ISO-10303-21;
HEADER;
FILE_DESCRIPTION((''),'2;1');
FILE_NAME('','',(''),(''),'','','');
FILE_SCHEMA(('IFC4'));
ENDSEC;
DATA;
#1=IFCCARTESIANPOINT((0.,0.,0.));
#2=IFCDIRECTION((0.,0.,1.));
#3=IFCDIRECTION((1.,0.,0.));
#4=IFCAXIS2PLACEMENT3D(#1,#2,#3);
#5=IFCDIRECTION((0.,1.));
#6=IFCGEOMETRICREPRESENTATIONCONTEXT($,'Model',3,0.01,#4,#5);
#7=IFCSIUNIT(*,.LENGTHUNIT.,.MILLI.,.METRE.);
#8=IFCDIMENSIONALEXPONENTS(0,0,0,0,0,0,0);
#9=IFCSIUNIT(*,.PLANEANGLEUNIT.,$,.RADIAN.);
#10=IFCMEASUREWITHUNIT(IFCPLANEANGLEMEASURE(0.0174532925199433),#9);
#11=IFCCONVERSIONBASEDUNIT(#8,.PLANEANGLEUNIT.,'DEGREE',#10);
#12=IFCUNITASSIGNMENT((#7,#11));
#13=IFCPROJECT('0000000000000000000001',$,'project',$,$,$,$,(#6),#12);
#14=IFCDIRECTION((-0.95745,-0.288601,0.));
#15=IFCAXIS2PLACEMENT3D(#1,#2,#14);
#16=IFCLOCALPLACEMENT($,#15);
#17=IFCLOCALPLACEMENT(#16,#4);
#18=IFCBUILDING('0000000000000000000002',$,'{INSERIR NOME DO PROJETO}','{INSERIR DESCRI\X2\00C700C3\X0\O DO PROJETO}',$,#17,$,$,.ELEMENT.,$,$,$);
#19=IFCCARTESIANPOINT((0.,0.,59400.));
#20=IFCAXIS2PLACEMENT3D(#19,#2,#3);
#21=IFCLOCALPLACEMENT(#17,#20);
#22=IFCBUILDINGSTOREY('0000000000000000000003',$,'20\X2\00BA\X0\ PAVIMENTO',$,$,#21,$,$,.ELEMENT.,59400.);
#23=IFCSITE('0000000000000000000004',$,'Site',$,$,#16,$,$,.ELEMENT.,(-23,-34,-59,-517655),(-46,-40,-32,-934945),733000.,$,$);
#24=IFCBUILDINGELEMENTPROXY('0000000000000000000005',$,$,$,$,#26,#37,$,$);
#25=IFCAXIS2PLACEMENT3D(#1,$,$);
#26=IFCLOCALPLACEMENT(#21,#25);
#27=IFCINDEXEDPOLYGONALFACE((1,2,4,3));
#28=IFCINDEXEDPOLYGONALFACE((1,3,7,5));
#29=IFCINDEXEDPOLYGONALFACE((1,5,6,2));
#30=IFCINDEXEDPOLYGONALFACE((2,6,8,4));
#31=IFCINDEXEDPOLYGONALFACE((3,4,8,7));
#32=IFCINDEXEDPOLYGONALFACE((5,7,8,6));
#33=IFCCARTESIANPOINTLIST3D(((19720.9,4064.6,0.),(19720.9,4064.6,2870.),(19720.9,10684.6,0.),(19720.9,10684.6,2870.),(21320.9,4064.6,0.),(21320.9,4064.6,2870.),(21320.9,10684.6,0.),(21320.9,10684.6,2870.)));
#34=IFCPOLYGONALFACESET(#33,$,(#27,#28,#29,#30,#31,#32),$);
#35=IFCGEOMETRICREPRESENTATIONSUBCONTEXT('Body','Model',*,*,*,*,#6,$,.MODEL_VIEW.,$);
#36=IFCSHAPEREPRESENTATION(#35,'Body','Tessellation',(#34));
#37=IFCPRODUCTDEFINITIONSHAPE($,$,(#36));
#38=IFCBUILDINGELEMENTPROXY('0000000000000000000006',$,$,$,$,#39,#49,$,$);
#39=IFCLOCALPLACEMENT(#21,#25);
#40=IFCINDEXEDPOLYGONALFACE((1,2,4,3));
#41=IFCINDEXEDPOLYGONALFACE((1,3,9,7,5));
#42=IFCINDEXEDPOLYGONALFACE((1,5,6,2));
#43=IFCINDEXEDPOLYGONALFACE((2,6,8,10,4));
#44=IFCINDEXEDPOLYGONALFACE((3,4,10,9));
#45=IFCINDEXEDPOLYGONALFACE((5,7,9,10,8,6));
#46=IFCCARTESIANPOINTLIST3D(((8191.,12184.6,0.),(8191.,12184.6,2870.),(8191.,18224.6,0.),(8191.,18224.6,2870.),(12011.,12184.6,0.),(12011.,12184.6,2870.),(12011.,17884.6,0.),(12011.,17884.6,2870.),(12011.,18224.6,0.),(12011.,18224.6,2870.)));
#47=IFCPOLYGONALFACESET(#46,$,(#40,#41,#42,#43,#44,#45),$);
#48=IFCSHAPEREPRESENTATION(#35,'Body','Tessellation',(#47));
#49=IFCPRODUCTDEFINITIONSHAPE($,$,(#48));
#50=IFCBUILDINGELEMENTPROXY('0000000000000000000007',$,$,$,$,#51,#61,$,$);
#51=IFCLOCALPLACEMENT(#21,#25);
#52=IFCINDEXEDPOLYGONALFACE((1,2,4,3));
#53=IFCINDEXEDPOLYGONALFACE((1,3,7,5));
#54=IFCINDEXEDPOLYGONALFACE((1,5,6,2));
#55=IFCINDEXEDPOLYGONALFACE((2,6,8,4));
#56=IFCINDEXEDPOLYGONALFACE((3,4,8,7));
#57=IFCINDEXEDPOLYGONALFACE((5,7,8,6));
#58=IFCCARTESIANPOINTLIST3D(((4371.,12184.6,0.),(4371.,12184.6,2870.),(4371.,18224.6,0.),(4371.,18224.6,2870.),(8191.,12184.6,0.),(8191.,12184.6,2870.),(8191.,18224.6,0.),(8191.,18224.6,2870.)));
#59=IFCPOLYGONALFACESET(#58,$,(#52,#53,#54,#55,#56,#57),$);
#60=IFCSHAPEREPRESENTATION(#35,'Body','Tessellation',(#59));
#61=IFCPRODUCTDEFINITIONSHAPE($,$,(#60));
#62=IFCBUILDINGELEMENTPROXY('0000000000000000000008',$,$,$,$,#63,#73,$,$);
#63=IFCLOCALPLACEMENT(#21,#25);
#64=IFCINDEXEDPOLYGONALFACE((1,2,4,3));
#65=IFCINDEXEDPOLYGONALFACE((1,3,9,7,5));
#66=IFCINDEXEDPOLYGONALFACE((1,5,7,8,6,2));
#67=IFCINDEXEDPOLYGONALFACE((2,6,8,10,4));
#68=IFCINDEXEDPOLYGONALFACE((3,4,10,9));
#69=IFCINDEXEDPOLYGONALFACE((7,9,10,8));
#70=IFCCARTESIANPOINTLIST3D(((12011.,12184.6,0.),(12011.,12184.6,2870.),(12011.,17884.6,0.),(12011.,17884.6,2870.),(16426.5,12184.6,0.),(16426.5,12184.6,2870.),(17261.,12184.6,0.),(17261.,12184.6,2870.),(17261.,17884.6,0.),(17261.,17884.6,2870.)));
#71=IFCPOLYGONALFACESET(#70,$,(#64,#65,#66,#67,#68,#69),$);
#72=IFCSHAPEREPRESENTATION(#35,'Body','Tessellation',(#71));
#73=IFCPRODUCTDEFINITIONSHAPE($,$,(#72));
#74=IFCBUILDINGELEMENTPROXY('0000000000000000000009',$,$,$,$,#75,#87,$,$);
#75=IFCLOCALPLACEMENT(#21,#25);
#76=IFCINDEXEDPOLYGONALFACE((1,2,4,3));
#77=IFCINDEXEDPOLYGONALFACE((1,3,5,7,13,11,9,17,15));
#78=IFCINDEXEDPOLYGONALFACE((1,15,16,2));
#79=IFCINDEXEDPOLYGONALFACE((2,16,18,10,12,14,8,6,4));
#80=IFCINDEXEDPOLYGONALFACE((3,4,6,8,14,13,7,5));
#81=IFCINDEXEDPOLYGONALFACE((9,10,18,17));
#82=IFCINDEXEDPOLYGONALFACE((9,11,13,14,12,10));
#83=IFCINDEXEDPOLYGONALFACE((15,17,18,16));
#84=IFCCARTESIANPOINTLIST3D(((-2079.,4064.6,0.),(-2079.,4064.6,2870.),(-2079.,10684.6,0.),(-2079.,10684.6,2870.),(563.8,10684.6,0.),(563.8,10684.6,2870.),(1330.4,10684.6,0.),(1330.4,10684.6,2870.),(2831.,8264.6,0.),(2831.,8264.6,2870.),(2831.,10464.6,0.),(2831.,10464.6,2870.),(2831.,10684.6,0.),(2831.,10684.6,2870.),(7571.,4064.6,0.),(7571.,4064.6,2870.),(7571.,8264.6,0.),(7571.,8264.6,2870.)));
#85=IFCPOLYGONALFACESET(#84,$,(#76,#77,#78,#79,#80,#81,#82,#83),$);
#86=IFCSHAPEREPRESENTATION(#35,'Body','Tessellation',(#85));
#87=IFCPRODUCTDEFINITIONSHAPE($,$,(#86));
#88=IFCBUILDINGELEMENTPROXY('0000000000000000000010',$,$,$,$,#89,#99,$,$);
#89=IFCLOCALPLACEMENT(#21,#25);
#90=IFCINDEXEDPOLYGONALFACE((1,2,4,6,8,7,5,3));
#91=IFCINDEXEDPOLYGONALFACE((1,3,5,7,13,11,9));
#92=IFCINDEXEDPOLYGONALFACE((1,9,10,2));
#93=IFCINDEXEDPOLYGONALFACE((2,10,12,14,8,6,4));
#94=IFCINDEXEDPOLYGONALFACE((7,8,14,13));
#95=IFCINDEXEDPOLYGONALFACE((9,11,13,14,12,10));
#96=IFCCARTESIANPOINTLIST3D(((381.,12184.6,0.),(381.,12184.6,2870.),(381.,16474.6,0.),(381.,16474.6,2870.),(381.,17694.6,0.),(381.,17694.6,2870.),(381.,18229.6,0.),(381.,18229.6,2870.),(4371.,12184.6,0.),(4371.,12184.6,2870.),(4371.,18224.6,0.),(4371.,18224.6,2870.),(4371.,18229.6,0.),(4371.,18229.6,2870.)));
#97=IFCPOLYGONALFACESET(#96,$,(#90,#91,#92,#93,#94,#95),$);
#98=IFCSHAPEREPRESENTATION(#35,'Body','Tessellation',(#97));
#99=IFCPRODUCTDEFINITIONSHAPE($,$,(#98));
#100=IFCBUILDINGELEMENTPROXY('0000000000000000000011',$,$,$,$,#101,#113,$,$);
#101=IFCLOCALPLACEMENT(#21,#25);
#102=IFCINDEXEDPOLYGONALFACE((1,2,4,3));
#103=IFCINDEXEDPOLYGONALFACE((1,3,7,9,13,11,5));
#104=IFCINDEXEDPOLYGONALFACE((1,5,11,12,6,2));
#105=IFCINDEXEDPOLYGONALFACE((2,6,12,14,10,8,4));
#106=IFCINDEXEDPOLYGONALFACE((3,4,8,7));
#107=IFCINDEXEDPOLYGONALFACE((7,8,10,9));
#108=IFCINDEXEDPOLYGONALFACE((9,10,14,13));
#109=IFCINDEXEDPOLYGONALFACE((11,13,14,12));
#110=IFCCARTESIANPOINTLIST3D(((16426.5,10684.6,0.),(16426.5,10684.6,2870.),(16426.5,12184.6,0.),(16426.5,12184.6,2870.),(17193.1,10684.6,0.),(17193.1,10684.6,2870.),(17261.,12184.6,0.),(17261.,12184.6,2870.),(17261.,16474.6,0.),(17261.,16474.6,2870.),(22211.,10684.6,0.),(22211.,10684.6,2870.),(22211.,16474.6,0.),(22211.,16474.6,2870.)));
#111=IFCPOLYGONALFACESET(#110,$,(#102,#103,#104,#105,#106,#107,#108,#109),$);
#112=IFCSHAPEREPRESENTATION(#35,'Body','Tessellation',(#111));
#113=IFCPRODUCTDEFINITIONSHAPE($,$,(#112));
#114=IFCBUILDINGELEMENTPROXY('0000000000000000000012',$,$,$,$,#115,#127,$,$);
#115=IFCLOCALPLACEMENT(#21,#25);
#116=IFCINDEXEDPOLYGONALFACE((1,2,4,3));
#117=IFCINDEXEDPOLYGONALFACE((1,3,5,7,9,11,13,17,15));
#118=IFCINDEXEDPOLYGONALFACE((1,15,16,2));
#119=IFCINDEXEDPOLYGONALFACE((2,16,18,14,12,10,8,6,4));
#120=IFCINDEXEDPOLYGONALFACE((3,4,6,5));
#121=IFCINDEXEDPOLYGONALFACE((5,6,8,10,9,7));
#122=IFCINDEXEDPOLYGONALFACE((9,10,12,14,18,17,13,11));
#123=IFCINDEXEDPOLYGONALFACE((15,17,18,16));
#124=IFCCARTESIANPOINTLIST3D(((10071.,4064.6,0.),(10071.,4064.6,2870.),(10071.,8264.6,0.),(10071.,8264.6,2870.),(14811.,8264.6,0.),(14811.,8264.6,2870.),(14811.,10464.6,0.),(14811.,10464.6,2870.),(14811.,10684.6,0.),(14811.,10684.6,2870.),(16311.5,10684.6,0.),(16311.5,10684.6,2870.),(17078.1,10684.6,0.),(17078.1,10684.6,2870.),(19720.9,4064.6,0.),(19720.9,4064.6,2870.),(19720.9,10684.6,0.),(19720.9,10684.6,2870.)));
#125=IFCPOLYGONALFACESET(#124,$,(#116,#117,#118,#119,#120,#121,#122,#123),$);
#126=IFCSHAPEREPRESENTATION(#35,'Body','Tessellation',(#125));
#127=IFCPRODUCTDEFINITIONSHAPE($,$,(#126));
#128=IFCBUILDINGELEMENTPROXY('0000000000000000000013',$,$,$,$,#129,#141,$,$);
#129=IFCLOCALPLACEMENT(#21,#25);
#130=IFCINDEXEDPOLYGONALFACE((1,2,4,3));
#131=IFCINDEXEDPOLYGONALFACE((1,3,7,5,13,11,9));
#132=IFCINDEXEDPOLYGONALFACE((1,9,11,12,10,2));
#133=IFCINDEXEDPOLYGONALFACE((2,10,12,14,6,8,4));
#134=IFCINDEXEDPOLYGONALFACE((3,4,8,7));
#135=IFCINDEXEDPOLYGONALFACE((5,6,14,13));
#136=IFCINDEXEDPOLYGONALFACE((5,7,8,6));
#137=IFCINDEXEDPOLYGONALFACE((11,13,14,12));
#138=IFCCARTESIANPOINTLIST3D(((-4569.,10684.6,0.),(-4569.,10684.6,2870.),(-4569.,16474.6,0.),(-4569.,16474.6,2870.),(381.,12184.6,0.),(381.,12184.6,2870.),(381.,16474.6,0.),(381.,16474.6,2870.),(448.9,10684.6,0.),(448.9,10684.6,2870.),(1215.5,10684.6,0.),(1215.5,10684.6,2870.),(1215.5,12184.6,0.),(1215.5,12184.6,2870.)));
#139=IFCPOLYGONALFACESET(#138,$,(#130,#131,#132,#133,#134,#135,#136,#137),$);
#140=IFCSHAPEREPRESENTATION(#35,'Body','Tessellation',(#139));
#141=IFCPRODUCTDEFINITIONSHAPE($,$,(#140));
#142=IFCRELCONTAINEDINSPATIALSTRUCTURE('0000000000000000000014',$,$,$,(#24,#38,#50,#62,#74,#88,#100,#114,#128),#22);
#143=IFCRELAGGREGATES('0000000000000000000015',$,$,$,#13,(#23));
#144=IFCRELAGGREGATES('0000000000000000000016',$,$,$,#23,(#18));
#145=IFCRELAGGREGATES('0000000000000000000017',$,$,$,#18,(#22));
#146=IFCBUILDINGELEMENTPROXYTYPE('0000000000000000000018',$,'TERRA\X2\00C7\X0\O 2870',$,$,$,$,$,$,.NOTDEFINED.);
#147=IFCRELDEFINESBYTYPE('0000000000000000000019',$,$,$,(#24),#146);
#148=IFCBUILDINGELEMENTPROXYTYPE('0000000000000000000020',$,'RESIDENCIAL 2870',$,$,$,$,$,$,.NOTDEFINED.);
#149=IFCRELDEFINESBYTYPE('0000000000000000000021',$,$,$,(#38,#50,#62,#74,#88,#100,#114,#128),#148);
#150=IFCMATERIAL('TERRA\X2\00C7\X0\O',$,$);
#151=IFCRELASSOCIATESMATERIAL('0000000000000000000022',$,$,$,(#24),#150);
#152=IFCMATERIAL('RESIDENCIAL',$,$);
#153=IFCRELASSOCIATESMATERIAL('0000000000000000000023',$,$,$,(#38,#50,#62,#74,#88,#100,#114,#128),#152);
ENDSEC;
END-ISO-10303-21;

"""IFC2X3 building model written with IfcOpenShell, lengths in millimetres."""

from ifc_helpers import new_model, entity, si_unit, converted_unit, direction, frame, origin_with_axes, place, context, subcontext, project, spatial, polyline, outline, extrude, material, type_object, element, save


model = new_model("IFC2X3")

# Units and contexts
model_context = context("Model", 3, precision=0.01, world=origin_with_axes(), true_north=direction((0.0, 1.0)))
body_context = subcontext(model_context, "Body", "Model", "MODEL_VIEW")
ifc_project = project(units=[si_unit("LENGTHUNIT", "METRE", prefix="MILLI"), converted_unit("PLANEANGLEUNIT", "DEGREE", entity("IfcPlaneAngleMeasure", 0.0174532925199433), si_unit("PLANEANGLEUNIT", "RADIAN"), dimensions=[0, 0, 0, 0, 0, 0, 0])], contexts=[model_context])

# Site, building, storey
site_placement = place(None, frame((0.0, 0.0, 0.0), z_axis=(0.0, 0.0, 1.0), x_axis=(-0.95745, -0.288601, 0.0)))
site = spatial("IfcSite", under=ifc_project, at=site_placement, Name="Site", CompositionType="ELEMENT", RefLatitude=(-23, -34, -59, -517655), RefLongitude=(-46, -40, -32, -934945), RefElevation=733000.0)
building_placement = place(site_placement, origin_with_axes())
building = spatial("IfcBuilding", under=site, at=building_placement, Name="{INSERIR NOME DO PROJETO}", Description="{INSERIR DESCRIÇÃO DO PROJETO}", CompositionType="ELEMENT")
storey_placement = place(building_placement, frame((0.0, 0.0, 59400.0), z_axis=(0.0, 0.0, 1.0), x_axis=(1.0, 0.0, 0.0)))
storey = spatial("IfcBuildingStorey", under=building, at=storey_placement, Name="20º PAVIMENTO", CompositionType="ELEMENT", Elevation=59400.0)

# Building element proxies
ifc_material_1 = material(Name="TERRAÇO")
building_element_proxy_type_1 = type_object("IfcBuildingElementProxyType", Name="TERRAÇO 2870", PredefinedType="NOTDEFINED")
proxy_1_placement = place(storey_placement, frame((21320.9, 4064.6, 0.0), z_axis=(0.0, 0.0, 1.0), x_axis=(1.0, 0.0, 0.0)))
element("IfcBuildingElementProxy", 1, at=proxy_1_placement, inside=storey, type_object=building_element_proxy_type_1, material=ifc_material_1, context=body_context, shape_type="SweptSolid", body=[
    extrude(outline(polyline([(0.0, 0.0), (0.0, 6620.0), (-1600.0, 6620.0), (-1600.0, 0.0), (0.0, 0.0)])), origin_with_axes(), (0.0, 0.0, 1.0), 2870.0),
])
ifc_material_2 = material(Name="RESIDENCIAL")
building_element_proxy_type_2 = type_object("IfcBuildingElementProxyType", Name="RESIDENCIAL 2870", PredefinedType="NOTDEFINED")
proxy_2_placement = place(storey_placement, frame((8191.0, 18224.6, 0.0), z_axis=(0.0, 0.0, 1.0), x_axis=(1.0, 0.0, 0.0)))
element("IfcBuildingElementProxy", 2, at=proxy_2_placement, inside=storey, type_object=building_element_proxy_type_2, material=ifc_material_2, context=body_context, shape_type="SweptSolid", body=[
    extrude(outline(polyline([(0.0, 0.0), (0.0, -6040.0), (3820.0, -6040.0), (3820.0, -340.0), (3820.0, 0.0), (0.0, 0.0)])), origin_with_axes(), (0.0, 0.0, 1.0), 2870.0),
])
proxy_3_placement = place(storey_placement, frame((4371.0, 18224.6, 0.0), z_axis=(0.0, 0.0, 1.0), x_axis=(1.0, 0.0, 0.0)))
element("IfcBuildingElementProxy", 3, at=proxy_3_placement, inside=storey, type_object=building_element_proxy_type_2, material=ifc_material_2, context=body_context, shape_type="SweptSolid", body=[
    extrude(outline(polyline([(0.0, 0.0), (0.0, -6040.0), (3820.0, -6040.0), (3820.0, 0.0), (0.0, 0.0)])), origin_with_axes(), (0.0, 0.0, 1.0), 2870.0),
])
proxy_4_placement = place(storey_placement, frame((12011.0, 12184.6, 0.0), z_axis=(0.0, 0.0, 1.0), x_axis=(1.0, 0.0, 0.0)))
element("IfcBuildingElementProxy", 4, at=proxy_4_placement, inside=storey, type_object=building_element_proxy_type_2, material=ifc_material_2, context=body_context, shape_type="SweptSolid", body=[
    extrude(outline(polyline([(0.0, 0.0), (4415.5, 0.0), (5250.0, 0.0), (5250.0, 5700.0), (0.0, 5700.0), (0.0, 0.0)])), origin_with_axes(), (0.0, 0.0, 1.0), 2870.0),
])
proxy_5_placement = place(storey_placement, frame((-2079.0, 4064.6, 0.0), z_axis=(0.0, 0.0, 1.0), x_axis=(1.0, 0.0, 0.0)))
element("IfcBuildingElementProxy", 5, at=proxy_5_placement, inside=storey, type_object=building_element_proxy_type_2, material=ifc_material_2, context=body_context, shape_type="SweptSolid", body=[
    extrude(outline(polyline([(0.0, 0.0), (9650.0, 0.0), (9650.0, 4200.0), (4910.0, 4200.0), (4910.0, 6400.0), (4910.0, 6620.0), (3409.4, 6620.0), (2642.8, 6620.0), (0.0, 6620.0), (0.0, 0.0)])), origin_with_axes(), (0.0, 0.0, 1.0), 2870.0),
])
proxy_6_placement = place(storey_placement, frame((381.0, 16474.6, 0.0), z_axis=(0.0, 0.0, 1.0), x_axis=(1.0, 0.0, 0.0)))
element("IfcBuildingElementProxy", 6, at=proxy_6_placement, inside=storey, type_object=building_element_proxy_type_2, material=ifc_material_2, context=body_context, shape_type="SweptSolid", body=[
    extrude(outline(polyline([(0.0, 0.0), (0.0, -4290.0), (3990.0, -4290.0), (3990.0, 1750.0), (3990.0, 1755.0), (0.0, 1755.0), (0.0, 1220.0), (0.0, 0.0)])), origin_with_axes(), (0.0, 0.0, 1.0), 2870.0),
])
proxy_7_placement = place(storey_placement, frame((17261.0, 12184.6, 0.0), z_axis=(0.0, 0.0, 1.0), x_axis=(1.0, 0.0, 0.0)))
element("IfcBuildingElementProxy", 7, at=proxy_7_placement, inside=storey, type_object=building_element_proxy_type_2, material=ifc_material_2, context=body_context, shape_type="SweptSolid", body=[
    extrude(outline(polyline([(0.0, 0.0), (-834.5, 0.0), (-834.5, -1500.0), (-67.9, -1500.0), (4950.0, -1500.0), (4950.0, 4290.0), (0.0, 4290.0), (0.0, 0.0)])), origin_with_axes(), (0.0, 0.0, 1.0), 2870.0),
])
proxy_8_placement = place(storey_placement, frame((19720.9, 4064.6, 0.0), z_axis=(0.0, 0.0, 1.0), x_axis=(1.0, 0.0, 0.0)))
element("IfcBuildingElementProxy", 8, at=proxy_8_placement, inside=storey, type_object=building_element_proxy_type_2, material=ifc_material_2, context=body_context, shape_type="SweptSolid", body=[
    extrude(outline(polyline([(0.0, 0.0), (0.0, 6620.0), (-2642.8, 6620.0), (-3409.4, 6620.0), (-4910.0, 6620.0), (-4910.0, 6400.0), (-4910.0, 4200.0), (-9650.0, 4200.0), (-9650.0, 0.0), (0.0, 0.0)])), origin_with_axes(), (0.0, 0.0, 1.0), 2870.0),
])
proxy_9_placement = place(storey_placement, frame((-4569.0, 16474.6, 0.0), z_axis=(0.0, 0.0, 1.0), x_axis=(1.0, 0.0, 0.0)))
element("IfcBuildingElementProxy", 9, at=proxy_9_placement, inside=storey, type_object=building_element_proxy_type_2, material=ifc_material_2, context=body_context, shape_type="SweptSolid", body=[
    extrude(outline(polyline([(0.0, 0.0), (0.0, -5790.0), (5017.9, -5790.0), (5784.5, -5790.0), (5784.5, -4290.0), (4950.0, -4290.0), (4950.0, 0.0), (0.0, 0.0)])), origin_with_axes(), (0.0, 0.0, 1.0), 2870.0),
])

save(model, "model.ifc")
